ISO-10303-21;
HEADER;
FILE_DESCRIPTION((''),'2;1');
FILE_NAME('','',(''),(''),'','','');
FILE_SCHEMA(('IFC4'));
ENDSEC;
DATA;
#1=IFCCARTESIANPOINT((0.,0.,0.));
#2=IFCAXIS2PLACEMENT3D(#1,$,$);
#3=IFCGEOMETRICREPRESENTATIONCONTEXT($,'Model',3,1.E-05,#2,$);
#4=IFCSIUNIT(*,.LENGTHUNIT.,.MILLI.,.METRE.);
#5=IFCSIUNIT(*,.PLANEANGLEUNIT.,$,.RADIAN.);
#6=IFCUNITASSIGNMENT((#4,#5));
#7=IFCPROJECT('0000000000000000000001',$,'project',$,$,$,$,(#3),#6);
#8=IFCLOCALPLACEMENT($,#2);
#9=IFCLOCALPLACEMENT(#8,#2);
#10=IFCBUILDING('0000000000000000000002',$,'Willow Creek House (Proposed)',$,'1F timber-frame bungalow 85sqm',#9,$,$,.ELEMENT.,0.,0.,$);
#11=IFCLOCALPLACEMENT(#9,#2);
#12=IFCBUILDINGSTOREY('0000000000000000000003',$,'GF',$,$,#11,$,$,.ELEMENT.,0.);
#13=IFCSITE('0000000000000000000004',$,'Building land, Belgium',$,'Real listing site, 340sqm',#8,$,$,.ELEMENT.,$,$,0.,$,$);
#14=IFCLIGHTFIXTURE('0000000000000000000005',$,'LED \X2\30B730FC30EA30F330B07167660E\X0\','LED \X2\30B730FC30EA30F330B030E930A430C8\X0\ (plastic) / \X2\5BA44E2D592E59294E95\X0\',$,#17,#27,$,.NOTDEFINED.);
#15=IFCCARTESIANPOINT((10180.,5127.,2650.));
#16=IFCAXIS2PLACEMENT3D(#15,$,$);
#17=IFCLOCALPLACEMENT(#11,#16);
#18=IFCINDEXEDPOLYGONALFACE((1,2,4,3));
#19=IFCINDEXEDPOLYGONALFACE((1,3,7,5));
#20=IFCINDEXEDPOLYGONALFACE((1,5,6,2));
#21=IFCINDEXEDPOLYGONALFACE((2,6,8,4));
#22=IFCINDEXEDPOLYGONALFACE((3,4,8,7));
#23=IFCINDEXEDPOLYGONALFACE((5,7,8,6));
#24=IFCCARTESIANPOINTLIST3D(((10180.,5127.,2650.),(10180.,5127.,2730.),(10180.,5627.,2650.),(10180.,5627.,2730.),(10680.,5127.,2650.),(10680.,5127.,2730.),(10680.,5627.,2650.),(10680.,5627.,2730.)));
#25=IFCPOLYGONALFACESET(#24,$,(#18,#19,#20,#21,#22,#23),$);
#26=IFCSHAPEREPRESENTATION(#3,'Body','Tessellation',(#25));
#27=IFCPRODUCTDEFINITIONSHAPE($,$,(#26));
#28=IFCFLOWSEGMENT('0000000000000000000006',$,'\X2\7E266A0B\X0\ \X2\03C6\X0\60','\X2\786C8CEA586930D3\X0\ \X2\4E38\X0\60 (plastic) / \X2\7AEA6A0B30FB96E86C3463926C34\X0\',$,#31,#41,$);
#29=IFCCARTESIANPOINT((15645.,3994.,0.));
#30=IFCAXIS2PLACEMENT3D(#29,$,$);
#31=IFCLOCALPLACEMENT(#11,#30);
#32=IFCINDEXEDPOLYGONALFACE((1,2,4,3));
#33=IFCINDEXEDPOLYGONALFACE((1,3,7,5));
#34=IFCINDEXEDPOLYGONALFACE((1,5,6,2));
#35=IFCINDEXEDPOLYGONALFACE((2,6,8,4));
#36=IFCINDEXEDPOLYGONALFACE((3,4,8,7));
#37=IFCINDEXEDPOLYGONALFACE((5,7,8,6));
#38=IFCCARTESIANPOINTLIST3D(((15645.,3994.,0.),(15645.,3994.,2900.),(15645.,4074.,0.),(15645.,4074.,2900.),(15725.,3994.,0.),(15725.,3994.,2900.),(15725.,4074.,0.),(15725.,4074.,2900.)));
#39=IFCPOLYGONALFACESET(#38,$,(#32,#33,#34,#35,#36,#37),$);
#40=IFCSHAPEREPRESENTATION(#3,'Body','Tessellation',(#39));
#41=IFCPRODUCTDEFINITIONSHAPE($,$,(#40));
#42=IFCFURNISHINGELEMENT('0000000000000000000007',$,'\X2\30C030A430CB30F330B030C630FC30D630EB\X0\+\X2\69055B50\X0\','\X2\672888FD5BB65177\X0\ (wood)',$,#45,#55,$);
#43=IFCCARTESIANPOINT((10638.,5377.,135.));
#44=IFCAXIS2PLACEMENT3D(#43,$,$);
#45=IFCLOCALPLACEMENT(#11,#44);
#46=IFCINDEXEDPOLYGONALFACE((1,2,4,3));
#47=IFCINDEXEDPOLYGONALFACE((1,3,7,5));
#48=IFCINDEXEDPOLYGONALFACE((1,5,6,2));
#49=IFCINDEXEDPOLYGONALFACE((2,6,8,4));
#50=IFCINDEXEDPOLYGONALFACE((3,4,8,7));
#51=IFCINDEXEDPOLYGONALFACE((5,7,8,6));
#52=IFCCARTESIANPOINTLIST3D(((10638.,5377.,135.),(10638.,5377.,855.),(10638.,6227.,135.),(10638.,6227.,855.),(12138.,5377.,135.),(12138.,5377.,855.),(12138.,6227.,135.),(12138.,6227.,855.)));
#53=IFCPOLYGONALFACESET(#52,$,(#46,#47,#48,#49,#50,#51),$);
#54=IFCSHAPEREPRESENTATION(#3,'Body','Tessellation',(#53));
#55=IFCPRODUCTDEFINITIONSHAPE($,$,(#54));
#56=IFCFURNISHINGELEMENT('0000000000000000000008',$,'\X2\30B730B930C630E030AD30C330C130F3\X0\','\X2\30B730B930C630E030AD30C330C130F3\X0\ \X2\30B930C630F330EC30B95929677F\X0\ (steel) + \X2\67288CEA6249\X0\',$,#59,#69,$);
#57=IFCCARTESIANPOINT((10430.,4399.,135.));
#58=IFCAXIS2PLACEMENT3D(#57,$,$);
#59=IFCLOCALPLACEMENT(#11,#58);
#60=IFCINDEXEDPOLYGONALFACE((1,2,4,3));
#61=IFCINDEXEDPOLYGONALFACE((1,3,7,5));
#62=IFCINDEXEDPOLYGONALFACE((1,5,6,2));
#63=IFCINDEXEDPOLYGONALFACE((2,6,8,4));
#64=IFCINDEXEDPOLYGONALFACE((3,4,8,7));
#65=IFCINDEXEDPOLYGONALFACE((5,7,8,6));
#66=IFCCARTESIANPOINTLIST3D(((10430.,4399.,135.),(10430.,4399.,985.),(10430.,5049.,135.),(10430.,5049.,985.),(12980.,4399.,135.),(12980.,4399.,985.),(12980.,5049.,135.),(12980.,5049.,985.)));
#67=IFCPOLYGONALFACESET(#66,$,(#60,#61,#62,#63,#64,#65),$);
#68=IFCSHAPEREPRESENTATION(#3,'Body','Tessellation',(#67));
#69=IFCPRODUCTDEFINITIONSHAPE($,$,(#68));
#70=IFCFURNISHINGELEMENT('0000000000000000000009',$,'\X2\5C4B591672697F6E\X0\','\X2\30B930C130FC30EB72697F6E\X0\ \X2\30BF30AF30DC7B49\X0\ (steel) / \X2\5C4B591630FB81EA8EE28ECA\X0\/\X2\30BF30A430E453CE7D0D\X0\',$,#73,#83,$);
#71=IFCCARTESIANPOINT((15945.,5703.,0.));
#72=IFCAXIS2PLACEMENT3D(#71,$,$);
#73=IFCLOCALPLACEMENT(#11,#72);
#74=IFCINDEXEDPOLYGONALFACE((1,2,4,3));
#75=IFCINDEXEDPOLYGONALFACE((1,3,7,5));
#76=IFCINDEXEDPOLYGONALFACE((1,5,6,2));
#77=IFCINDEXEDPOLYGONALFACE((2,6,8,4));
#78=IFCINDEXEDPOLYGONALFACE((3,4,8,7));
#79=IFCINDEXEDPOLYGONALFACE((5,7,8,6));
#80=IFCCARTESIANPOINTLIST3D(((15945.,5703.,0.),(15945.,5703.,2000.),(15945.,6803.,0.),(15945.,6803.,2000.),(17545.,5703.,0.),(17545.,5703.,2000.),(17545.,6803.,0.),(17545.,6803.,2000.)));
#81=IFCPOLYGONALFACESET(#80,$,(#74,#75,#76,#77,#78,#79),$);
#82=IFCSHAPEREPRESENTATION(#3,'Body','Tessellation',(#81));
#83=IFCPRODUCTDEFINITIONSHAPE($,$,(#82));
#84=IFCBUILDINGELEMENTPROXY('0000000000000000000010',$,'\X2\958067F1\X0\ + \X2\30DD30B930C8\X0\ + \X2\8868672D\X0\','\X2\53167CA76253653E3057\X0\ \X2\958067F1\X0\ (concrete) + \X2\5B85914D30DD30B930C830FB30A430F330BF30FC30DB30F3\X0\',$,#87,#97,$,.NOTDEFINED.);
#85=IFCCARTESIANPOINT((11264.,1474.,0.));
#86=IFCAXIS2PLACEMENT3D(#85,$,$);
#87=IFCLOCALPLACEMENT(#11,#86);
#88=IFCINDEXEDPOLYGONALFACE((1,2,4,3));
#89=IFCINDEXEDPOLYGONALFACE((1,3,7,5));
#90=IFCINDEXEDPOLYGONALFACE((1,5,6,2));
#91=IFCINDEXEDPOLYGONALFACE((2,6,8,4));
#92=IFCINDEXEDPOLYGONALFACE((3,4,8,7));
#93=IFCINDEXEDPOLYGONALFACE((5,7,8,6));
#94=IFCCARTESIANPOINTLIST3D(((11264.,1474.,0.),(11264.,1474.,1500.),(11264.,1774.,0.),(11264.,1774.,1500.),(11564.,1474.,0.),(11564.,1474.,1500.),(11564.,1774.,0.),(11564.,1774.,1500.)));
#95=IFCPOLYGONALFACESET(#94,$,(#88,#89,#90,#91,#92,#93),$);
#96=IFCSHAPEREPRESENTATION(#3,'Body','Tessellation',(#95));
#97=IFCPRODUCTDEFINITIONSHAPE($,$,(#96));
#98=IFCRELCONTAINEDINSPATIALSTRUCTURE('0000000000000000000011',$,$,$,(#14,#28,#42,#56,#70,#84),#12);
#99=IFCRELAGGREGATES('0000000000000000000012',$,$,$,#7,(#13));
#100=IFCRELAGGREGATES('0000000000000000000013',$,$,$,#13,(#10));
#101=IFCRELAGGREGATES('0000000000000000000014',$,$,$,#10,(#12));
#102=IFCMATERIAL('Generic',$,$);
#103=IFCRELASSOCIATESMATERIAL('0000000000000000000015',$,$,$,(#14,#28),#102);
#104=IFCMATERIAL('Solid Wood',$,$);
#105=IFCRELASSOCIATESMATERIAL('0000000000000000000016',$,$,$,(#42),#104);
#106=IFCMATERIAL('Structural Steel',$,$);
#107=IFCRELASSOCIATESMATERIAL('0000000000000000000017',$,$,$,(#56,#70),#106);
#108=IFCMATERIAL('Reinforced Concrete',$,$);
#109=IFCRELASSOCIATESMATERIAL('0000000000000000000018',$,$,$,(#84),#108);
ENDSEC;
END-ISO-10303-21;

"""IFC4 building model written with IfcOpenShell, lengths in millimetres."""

from ifc_helpers import new_model, si_unit, frame, frame_2d, origin, place, context, project, spatial, rectangle, extrude, material, element, save


model = new_model("IFC4")

# Units and contexts
model_context = context("Model", 3, precision=1e-05, world=origin())
ifc_project = project(units=[si_unit("LENGTHUNIT", "METRE", prefix="MILLI"), si_unit("PLANEANGLEUNIT", "RADIAN")], contexts=[model_context])

# Site, building, storey
site_placement = place(None, origin())
site = spatial("IfcSite", under=ifc_project, at=site_placement, Name="Building land, Belgium", ObjectType="Real listing site, 340sqm", CompositionType="ELEMENT", RefElevation=0.0)
building_placement = place(site_placement, origin())
building = spatial("IfcBuilding", under=site, at=building_placement, Name="Willow Creek House (Proposed)", ObjectType="1F timber-frame bungalow 85sqm", CompositionType="ELEMENT", ElevationOfRefHeight=0.0, ElevationOfTerrain=0.0)
storey_placement = place(building_placement, origin())
storey = spatial("IfcBuildingStorey", under=building, at=storey_placement, Name="GF", CompositionType="ELEMENT", Elevation=0.0)

# Shared definitions
ifc_material_1 = material(Name="Solid Wood")

# Shared definitions
ifc_material_2 = material(Name="Structural Steel")

# Shared definitions
ifc_material_3 = material(Name="Reinforced Concrete")

# Shared definitions
ifc_material_4 = material(Name="Generic")

# Light fixture
light_fixture_placement = place(storey_placement, frame((10180.0, 5127.0, 2650.0)))
element("IfcLightFixture", 1, at=light_fixture_placement, inside=storey, material=ifc_material_4, Name="LED シーリング照明", Description="LED シーリングライト (plastic) / 室中央天井", PredefinedType="NOTDEFINED", context=model_context, shape_type="SweptSolid", body=[
    extrude(rectangle(XDim=500.0, YDim=500.0, at=frame_2d((250.0, 250.0))), frame((10180.0, 5127.0, 2650.0)), (0.0, 0.0, 1.0), 80.0),
])

# Flow segment
flow_segment_placement = place(storey_placement, frame((15645.0, 3994.0, 0.0)))
element("IfcFlowSegment", 2, at=flow_segment_placement, inside=storey, material=ifc_material_4, Name="縦樋 φ60", Description="硬質塩ビ 丸60 (plastic) / 竪樋・雨水排水", context=model_context, shape_type="SweptSolid", body=[
    extrude(rectangle(XDim=80.0, YDim=80.0, at=frame_2d((40.0, 40.0))), frame((15645.0, 3994.0, 0.0)), (0.0, 0.0, 1.0), 2900.0),
])

# Furnishing elements
furnishing_1_placement = place(storey_placement, frame((10638.0, 5377.0, 135.0)))
element("IfcFurnishingElement", 3, at=furnishing_1_placement, inside=storey, material=ifc_material_1, Name="ダイニングテーブル+椅子", Description="木製家具 (wood)", context=model_context, shape_type="SweptSolid", body=[
    extrude(rectangle(XDim=1500.0, YDim=850.0, at=frame_2d((750.0, 425.0))), frame((10638.0, 5377.0, 135.0)), (0.0, 0.0, 1.0), 720.0),
])
furnishing_2_placement = place(storey_placement, frame((10430.0, 4399.0, 135.0)))
element("IfcFurnishingElement", 4, at=furnishing_2_placement, inside=storey, material=ifc_material_2, Name="システムキッチン", Description="システムキッチン ステンレス天板 (steel) + 木質扉", context=model_context, shape_type="SweptSolid", body=[
    extrude(rectangle(XDim=2550.0, YDim=650.0, at=frame_2d((1275.0, 325.0))), frame((10430.0, 4399.0, 135.0)), (0.0, 0.0, 1.0), 850.0),
])
furnishing_3_placement = place(storey_placement, frame((15945.0, 5703.0, 0.0)))
element("IfcFurnishingElement", 5, at=furnishing_3_placement, inside=storey, material=ifc_material_2, Name="屋外物置", Description="スチール物置 タクボ等 (steel) / 屋外・自転車/タイヤ収納", context=model_context, shape_type="SweptSolid", body=[
    extrude(rectangle(XDim=1600.0, YDim=1100.0, at=frame_2d((800.0, 550.0))), frame((15945.0, 5703.0, 0.0)), (0.0, 0.0, 1.0), 2000.0),
])

# Building element proxy
proxy_placement = place(storey_placement, frame((11264.0, 1474.0, 0.0)))
element("IfcBuildingElementProxy", 6, at=proxy_placement, inside=storey, material=ifc_material_3, Name="門柱 + ポスト + 表札", Description="化粧打放し 門柱 (concrete) + 宅配ポスト・インターホン", PredefinedType="NOTDEFINED", context=model_context, shape_type="SweptSolid", body=[
    extrude(rectangle(XDim=300.0, YDim=300.0, at=frame_2d((150.0, 150.0))), frame((11264.0, 1474.0, 0.0)), (0.0, 0.0, 1.0), 1500.0),
])

save(model, "model.ifc")
